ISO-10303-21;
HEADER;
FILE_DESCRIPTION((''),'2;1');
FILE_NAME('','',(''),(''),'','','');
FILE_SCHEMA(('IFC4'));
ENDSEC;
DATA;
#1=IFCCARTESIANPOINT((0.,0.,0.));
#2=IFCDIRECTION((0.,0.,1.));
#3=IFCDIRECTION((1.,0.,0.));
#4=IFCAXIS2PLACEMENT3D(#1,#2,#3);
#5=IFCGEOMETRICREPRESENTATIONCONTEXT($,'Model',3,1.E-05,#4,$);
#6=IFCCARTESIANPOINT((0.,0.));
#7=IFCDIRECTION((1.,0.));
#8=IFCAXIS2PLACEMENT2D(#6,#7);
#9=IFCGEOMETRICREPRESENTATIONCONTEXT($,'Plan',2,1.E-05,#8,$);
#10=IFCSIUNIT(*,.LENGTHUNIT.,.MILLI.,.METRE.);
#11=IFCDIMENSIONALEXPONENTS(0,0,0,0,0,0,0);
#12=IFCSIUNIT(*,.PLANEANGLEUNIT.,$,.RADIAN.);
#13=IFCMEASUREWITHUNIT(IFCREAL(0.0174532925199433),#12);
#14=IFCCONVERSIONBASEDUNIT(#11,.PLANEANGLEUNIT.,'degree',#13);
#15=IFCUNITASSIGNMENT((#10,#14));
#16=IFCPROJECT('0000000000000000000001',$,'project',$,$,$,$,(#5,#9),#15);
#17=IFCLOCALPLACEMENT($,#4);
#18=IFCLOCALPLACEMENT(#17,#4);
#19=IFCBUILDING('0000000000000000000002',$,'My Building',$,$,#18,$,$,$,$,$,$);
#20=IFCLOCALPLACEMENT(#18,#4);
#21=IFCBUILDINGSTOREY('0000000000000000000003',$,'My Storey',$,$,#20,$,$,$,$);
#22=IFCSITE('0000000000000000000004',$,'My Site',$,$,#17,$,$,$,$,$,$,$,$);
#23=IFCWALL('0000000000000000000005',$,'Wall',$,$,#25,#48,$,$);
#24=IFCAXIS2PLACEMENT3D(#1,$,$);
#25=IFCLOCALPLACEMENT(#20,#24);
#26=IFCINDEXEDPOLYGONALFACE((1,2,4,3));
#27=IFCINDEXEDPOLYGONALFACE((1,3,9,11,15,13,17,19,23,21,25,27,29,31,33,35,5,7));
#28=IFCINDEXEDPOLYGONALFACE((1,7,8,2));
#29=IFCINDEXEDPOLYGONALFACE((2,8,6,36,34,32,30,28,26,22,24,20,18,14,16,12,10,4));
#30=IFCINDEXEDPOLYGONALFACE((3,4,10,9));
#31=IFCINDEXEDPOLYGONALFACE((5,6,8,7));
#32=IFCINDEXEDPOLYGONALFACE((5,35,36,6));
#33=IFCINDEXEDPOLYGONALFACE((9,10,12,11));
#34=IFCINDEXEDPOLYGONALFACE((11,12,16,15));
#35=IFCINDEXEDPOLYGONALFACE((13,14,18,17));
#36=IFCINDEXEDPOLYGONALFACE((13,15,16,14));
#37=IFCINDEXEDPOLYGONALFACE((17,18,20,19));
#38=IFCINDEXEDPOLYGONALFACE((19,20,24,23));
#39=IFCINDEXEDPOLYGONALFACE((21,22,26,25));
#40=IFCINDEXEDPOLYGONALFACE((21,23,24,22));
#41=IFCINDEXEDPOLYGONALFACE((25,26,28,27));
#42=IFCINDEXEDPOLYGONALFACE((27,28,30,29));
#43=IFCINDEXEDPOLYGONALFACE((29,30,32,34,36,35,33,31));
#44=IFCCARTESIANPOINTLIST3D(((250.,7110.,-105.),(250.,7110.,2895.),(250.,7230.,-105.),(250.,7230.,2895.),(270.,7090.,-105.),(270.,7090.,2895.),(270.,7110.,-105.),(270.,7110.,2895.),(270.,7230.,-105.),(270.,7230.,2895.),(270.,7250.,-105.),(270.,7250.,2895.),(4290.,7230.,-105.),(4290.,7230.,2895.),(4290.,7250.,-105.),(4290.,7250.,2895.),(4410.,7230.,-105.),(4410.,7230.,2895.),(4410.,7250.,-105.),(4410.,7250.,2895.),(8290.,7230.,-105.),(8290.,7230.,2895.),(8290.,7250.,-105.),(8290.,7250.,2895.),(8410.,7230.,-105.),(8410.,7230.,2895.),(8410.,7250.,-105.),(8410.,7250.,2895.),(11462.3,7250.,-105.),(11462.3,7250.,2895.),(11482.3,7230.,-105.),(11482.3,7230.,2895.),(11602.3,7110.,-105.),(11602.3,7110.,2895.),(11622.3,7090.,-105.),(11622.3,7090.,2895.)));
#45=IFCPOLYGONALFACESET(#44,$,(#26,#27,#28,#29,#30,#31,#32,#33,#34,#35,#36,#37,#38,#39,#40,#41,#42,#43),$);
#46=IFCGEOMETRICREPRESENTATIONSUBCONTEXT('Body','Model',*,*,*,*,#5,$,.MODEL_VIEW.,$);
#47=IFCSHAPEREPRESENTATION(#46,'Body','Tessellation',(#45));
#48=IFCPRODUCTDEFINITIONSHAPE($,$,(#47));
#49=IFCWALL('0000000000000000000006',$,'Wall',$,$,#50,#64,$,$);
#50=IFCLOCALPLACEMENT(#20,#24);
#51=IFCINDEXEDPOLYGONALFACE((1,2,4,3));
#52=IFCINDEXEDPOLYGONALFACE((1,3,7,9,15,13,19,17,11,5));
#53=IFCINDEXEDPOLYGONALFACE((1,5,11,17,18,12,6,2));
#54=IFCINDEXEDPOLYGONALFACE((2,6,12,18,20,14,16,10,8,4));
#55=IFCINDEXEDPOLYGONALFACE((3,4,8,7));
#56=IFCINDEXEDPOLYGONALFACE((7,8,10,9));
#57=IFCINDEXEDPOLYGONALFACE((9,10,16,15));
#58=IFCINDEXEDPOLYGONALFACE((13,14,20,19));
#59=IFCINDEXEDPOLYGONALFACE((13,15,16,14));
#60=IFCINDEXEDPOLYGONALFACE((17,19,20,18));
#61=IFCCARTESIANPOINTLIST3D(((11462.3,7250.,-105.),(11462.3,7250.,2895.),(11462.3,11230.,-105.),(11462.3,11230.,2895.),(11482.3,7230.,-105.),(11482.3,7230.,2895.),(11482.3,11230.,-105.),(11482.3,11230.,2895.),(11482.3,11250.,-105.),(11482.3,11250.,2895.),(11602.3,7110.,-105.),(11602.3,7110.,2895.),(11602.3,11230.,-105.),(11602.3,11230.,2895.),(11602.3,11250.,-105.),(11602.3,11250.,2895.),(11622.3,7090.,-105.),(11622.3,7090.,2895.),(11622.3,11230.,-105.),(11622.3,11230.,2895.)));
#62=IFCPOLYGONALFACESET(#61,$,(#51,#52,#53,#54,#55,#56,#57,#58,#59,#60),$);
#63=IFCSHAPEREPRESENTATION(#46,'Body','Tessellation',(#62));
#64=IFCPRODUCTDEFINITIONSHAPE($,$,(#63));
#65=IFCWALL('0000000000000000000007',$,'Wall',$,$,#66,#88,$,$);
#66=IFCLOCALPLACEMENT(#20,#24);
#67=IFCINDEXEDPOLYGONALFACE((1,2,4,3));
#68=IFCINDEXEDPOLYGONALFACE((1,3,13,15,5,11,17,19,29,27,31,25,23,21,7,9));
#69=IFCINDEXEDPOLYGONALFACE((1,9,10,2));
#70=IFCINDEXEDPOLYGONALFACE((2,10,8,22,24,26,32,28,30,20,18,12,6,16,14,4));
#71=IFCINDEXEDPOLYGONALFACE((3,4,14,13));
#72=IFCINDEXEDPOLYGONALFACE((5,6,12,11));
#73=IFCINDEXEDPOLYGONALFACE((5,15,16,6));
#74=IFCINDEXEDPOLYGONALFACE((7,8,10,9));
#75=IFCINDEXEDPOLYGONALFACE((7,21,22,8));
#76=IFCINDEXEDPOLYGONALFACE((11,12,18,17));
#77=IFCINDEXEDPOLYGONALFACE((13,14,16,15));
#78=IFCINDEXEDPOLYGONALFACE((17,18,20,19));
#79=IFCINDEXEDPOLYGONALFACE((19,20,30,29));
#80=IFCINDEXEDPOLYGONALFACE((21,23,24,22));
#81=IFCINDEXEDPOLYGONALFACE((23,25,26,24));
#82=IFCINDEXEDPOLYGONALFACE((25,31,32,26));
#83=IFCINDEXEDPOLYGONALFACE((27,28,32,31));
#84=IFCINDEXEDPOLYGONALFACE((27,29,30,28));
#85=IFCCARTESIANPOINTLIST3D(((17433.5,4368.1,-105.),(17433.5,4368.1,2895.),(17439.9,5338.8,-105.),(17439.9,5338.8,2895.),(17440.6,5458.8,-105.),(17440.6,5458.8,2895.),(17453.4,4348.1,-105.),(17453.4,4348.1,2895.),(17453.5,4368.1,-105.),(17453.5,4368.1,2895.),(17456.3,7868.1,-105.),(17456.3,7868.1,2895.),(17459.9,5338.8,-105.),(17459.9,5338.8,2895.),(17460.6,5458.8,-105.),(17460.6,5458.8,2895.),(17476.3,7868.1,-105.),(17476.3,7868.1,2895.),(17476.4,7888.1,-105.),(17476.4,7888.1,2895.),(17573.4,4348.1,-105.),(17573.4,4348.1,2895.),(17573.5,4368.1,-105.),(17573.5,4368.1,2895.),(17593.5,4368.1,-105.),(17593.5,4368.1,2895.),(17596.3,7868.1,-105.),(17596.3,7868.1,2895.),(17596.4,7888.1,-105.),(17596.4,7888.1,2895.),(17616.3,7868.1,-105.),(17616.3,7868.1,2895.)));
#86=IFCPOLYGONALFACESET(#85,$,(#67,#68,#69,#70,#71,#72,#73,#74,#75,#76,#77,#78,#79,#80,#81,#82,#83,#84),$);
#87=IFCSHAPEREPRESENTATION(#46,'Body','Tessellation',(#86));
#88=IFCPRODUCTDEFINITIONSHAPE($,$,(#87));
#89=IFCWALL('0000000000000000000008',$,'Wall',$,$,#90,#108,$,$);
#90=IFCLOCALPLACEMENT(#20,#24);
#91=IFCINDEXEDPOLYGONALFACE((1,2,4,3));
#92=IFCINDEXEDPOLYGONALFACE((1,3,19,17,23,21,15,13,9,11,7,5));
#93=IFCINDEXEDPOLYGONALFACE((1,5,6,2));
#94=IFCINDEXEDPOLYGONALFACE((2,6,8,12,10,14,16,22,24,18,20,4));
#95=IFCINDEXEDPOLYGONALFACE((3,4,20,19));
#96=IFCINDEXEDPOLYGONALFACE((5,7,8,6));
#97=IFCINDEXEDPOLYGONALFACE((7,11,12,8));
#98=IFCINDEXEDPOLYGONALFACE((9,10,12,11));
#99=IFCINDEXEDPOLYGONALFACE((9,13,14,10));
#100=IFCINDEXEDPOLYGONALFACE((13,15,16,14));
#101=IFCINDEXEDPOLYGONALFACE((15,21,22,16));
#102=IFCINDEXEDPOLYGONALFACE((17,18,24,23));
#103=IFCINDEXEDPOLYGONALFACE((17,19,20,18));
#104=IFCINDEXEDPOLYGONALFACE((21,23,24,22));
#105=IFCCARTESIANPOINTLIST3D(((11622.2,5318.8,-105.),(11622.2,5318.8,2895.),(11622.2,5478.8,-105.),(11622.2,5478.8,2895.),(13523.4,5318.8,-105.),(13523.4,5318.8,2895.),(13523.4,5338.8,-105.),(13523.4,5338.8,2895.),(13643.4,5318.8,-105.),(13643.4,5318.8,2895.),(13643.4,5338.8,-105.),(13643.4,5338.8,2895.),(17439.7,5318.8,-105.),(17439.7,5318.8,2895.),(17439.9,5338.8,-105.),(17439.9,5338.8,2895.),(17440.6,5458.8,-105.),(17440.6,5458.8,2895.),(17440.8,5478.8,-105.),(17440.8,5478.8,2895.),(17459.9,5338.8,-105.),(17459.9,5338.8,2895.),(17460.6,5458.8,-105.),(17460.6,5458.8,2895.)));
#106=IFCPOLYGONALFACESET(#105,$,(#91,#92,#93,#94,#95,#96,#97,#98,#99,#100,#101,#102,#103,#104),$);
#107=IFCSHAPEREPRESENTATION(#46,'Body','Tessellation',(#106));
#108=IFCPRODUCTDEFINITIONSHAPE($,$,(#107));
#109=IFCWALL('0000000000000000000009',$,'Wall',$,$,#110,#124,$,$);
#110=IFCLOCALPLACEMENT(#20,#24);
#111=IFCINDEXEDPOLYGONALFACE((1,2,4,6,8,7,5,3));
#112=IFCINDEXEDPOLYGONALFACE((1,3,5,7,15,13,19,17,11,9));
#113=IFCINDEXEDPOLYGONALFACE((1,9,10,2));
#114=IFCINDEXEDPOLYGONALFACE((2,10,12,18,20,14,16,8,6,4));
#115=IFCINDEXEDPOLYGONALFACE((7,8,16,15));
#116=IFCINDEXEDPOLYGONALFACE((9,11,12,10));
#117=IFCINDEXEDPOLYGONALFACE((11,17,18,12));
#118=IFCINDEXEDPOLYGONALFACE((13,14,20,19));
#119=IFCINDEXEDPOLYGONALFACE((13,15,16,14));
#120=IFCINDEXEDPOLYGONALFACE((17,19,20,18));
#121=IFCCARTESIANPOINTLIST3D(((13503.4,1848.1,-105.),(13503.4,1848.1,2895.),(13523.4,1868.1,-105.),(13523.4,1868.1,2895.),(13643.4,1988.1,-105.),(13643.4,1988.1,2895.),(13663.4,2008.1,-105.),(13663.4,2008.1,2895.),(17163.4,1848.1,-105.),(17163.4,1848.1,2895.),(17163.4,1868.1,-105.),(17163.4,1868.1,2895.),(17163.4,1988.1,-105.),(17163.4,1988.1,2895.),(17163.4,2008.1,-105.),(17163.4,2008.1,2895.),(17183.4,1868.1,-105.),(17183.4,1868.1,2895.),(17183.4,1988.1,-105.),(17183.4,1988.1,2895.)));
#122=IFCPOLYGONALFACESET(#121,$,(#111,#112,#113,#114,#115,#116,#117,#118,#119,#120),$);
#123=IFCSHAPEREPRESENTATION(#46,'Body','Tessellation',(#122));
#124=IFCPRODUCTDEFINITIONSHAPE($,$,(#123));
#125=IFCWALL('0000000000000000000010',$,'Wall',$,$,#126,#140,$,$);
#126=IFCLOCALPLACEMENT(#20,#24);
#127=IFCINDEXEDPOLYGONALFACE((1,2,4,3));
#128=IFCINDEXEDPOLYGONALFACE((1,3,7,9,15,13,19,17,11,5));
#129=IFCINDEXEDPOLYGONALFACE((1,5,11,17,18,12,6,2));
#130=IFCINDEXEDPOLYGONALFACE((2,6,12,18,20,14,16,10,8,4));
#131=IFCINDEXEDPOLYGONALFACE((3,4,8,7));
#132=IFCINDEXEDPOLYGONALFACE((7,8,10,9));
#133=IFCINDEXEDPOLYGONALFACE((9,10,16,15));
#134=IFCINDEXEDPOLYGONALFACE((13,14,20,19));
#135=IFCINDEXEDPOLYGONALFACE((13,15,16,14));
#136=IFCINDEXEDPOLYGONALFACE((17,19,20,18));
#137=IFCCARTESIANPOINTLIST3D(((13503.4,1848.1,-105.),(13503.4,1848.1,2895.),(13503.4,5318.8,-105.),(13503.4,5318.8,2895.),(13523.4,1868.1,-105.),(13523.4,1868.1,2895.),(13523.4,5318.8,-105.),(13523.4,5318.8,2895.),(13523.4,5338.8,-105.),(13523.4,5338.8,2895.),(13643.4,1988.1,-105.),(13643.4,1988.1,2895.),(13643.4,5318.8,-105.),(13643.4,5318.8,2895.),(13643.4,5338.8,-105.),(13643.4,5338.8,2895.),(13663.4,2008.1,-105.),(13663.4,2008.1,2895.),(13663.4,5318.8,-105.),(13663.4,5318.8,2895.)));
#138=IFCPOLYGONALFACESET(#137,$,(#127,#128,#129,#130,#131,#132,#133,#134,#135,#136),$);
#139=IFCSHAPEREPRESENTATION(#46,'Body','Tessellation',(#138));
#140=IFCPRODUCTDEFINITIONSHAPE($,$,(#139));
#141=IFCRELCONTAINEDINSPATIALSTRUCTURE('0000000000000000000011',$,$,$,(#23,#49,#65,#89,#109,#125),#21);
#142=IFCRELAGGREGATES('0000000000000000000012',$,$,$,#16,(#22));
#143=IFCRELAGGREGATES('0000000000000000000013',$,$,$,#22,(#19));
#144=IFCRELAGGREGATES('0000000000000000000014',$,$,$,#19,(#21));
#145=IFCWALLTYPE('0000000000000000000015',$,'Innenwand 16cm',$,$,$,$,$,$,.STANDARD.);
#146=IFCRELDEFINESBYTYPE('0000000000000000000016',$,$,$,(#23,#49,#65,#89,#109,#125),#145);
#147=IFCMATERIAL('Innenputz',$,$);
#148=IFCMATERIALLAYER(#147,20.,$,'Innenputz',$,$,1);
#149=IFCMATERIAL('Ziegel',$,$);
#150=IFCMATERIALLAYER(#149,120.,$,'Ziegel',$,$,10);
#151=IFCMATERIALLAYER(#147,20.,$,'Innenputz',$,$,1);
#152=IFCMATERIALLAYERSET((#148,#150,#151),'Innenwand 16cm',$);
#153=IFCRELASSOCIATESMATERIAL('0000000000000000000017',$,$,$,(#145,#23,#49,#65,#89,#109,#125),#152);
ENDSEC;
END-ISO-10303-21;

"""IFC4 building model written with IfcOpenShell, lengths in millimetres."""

from ifc_helpers import new_model, entity, si_unit, converted_unit, frame, origin_with_axes, origin_2d_with_axis, place, context, subcontext, project, spatial, line, indexed_curve, outline, extrude, material, layer, layer_set, layer_usage, type_object, element, save


model = new_model("IFC4")

# Units and contexts
model_context = context("Model", 3, precision=1e-05, world=origin_with_axes())
plan_context = context("Plan", 2, precision=1e-05, world=origin_2d_with_axis())
body_context = subcontext(model_context, "Body", "Model", "MODEL_VIEW")
ifc_project = project(units=[si_unit("LENGTHUNIT", "METRE", prefix="MILLI"), converted_unit("PLANEANGLEUNIT", "degree", entity("IfcReal", 0.0174532925199433), si_unit("PLANEANGLEUNIT", "RADIAN"), dimensions=[0, 0, 0, 0, 0, 0, 0])], contexts=[model_context, plan_context])

# Site, building, storey
site_placement = place(None, origin_with_axes())
site = spatial("IfcSite", under=ifc_project, at=site_placement, Name="My Site")
building_placement = place(site_placement, origin_with_axes())
building = spatial("IfcBuilding", under=site, at=building_placement, Name="My Building")
storey_placement = place(building_placement, origin_with_axes())
storey = spatial("IfcBuildingStorey", under=building, at=storey_placement, Name="My Storey")

# Walls
ifc_material_1 = material(Name="Innenputz")
ifc_material_2 = material(Name="Ziegel")
ifc_layer_1 = layer(ifc_material_1, 20.0, Name="Innenputz", Priority=1)
ifc_layer_2 = layer(ifc_material_2, 120.0, Name="Ziegel", Priority=10)
ifc_layer_3 = layer(ifc_material_1, 20.0, Name="Innenputz", Priority=1)
ifc_layer_set_1 = layer_set([ifc_layer_1, ifc_layer_2, ifc_layer_3], Name="Innenwand 16cm")
ifc_layer_usage_1 = layer_usage(ifc_layer_set_1, "AXIS2", "POSITIVE", 0.0)
wall_type_1 = type_object("IfcWallType", Name="Innenwand 16cm", PredefinedType="STANDARD", material=ifc_layer_set_1)
wall_1_placement = place(storey_placement, frame((270.0, 7090.0, -105.0), z_axis=(0.0, 0.0, 1.0), x_axis=(1.0, 0.0, 0.0)))
element("IfcWall", 1, at=wall_1_placement, inside=storey, type_object=wall_type_1, material=ifc_layer_usage_1, Name="Wall", context=body_context, shape_type="SweptSolid", body=[
    extrude(outline(indexed_curve([(0.0, 0.0), (0.0, 20.0), (-20.0, 20.0), (-20.0, 140.0), (0.0, 140.0), (0.0, 160.0), (4020.0, 160.0), (4020.0, 140.0), (4140.0, 140.0), (4140.0, 160.0), (8020.0, 160.0), (8020.0, 140.0), (8140.0, 140.0), (8140.0, 160.0), (11192.3, 160.0), (11212.3, 140.0), (11332.3, 20.0), (11352.3, 0.0)], segments=[line(1, 2, 3, 4, 5, 6, 7, 8, 9, 10, 11, 12, 13, 14, 15, 16, 17, 18, 1)])), origin_with_axes(), (0.0, 0.0, 1.0), 3000.0),
])
ifc_layer_usage_2 = layer_usage(ifc_layer_set_1, "AXIS2", "POSITIVE", 0.0)
wall_2_placement = place(storey_placement, frame((11622.3, 7090.0, -105.0), z_axis=(0.0, 0.0, 1.0), x_axis=(0.0, 1.0, 0.0)))
element("IfcWall", 2, at=wall_2_placement, inside=storey, type_object=wall_type_1, material=ifc_layer_usage_2, Name="Wall", context=body_context, shape_type="SweptSolid", body=[
    extrude(outline(indexed_curve([(0.0, 0.0), (20.0, 20.0), (140.0, 140.0), (160.0, 160.0), (4140.0, 160.0), (4140.0, 140.0), (4160.0, 140.0), (4160.0, 20.0), (4140.0, 20.0), (4140.0, 0.0)], segments=[line(1, 2, 3, 4, 5, 6, 7, 8, 9, 10, 1)])), origin_with_axes(), (0.0, 0.0, 1.0), 3000.0),
])
ifc_layer_usage_3 = layer_usage(ifc_layer_set_1, "AXIS2", "POSITIVE", 0.0)
wall_3_placement = place(storey_placement, frame((17456.3, 7868.1, -105.0), z_axis=(0.0, 0.0, 1.0), x_axis=(-0.006503, -0.999979, 0.0)))
element("IfcWall", 3, at=wall_3_placement, inside=storey, type_object=wall_type_1, material=ifc_layer_usage_3, Name="Wall", context=body_context, shape_type="SweptSolid", body=[
    extrude(outline(indexed_curve([(0.0, 0.0), (-0.1, 20.0), (-20.1, 20.0), (-20.9, 140.0), (-0.9, 140.0), (-1.0, 160.0), (3499.0, 160.0), (3499.2, 140.0), (3519.2, 140.0), (3519.9, 20.0), (3499.9, 20.0), (3500.1, 0.0), (2529.3, 0.0), (2529.2, 20.0), (2409.2, 20.0), (2409.3, 0.0)], segments=[line(1, 2, 3, 4, 5, 6, 7, 8, 9, 10, 11, 12, 13, 14, 15, 16, 1)])), origin_with_axes(), (0.0, 0.0, 1.0), 3000.0),
])
ifc_layer_usage_4 = layer_usage(ifc_layer_set_1, "AXIS2", "POSITIVE", 0.0)
wall_4_placement = place(storey_placement, frame((11622.2, 5318.8, -105.0), z_axis=(0.0, 0.0, 1.0), x_axis=(1.0, 0.0, 0.0)))
element("IfcWall", 4, at=wall_4_placement, inside=storey, type_object=wall_type_1, material=ifc_layer_usage_4, Name="Wall", context=body_context, shape_type="SweptSolid", body=[
    extrude(outline(indexed_curve([(0.0, 0.0), (0.0, 160.0), (5818.5, 160.0), (5818.4, 140.0), (5838.4, 140.0), (5837.6, 20.0), (5817.6, 20.0), (5817.5, 0.0), (2021.2, 0.0), (2021.2, 20.0), (1901.2, 20.0), (1901.2, 0.0)], segments=[line(1, 2, 3, 4, 5, 6, 7, 8, 9, 10, 11, 12, 1)])), origin_with_axes(), (0.0, 0.0, 1.0), 3000.0),
])
ifc_layer_usage_5 = layer_usage(ifc_layer_set_1, "AXIS2", "POSITIVE", 0.0)
wall_5_placement = place(storey_placement, frame((17163.4, 2008.1, -105.0), z_axis=(0.0, 0.0, 1.0), x_axis=(-1.0, 0.0, 0.0)))
element("IfcWall", 5, at=wall_5_placement, inside=storey, type_object=wall_type_1, material=ifc_layer_usage_5, Name="Wall", context=body_context, shape_type="SweptSolid", body=[
    extrude(outline(indexed_curve([(0.0, 0.0), (0.0, 20.0), (-20.0, 20.0), (-20.0, 140.0), (0.0, 140.0), (0.0, 160.0), (3660.0, 160.0), (3640.0, 140.0), (3520.0, 20.0), (3500.0, 0.0)], segments=[line(1, 2, 3, 4, 5, 6, 7, 8, 9, 10, 1)])), origin_with_axes(), (0.0, 0.0, 1.0), 3000.0),
])
ifc_layer_usage_6 = layer_usage(ifc_layer_set_1, "AXIS2", "POSITIVE", 0.0)
wall_6_placement = place(storey_placement, frame((13663.4, 2008.1, -105.0), z_axis=(0.0, 0.0, 1.0), x_axis=(0.0, 1.0, 0.0)))
element("IfcWall", 6, at=wall_6_placement, inside=storey, type_object=wall_type_1, material=ifc_layer_usage_6, Name="Wall", context=body_context, shape_type="SweptSolid", body=[
    extrude(outline(indexed_curve([(0.0, 0.0), (-20.0, 20.0), (-140.0, 140.0), (-160.0, 160.0), (3310.8, 160.0), (3310.8, 140.0), (3330.8, 140.0), (3330.8, 20.0), (3310.8, 20.0), (3310.8, 0.0)], segments=[line(1, 2, 3, 4, 5, 6, 7, 8, 9, 10, 1)])), origin_with_axes(), (0.0, 0.0, 1.0), 3000.0),
])

save(model, "model.ifc")
